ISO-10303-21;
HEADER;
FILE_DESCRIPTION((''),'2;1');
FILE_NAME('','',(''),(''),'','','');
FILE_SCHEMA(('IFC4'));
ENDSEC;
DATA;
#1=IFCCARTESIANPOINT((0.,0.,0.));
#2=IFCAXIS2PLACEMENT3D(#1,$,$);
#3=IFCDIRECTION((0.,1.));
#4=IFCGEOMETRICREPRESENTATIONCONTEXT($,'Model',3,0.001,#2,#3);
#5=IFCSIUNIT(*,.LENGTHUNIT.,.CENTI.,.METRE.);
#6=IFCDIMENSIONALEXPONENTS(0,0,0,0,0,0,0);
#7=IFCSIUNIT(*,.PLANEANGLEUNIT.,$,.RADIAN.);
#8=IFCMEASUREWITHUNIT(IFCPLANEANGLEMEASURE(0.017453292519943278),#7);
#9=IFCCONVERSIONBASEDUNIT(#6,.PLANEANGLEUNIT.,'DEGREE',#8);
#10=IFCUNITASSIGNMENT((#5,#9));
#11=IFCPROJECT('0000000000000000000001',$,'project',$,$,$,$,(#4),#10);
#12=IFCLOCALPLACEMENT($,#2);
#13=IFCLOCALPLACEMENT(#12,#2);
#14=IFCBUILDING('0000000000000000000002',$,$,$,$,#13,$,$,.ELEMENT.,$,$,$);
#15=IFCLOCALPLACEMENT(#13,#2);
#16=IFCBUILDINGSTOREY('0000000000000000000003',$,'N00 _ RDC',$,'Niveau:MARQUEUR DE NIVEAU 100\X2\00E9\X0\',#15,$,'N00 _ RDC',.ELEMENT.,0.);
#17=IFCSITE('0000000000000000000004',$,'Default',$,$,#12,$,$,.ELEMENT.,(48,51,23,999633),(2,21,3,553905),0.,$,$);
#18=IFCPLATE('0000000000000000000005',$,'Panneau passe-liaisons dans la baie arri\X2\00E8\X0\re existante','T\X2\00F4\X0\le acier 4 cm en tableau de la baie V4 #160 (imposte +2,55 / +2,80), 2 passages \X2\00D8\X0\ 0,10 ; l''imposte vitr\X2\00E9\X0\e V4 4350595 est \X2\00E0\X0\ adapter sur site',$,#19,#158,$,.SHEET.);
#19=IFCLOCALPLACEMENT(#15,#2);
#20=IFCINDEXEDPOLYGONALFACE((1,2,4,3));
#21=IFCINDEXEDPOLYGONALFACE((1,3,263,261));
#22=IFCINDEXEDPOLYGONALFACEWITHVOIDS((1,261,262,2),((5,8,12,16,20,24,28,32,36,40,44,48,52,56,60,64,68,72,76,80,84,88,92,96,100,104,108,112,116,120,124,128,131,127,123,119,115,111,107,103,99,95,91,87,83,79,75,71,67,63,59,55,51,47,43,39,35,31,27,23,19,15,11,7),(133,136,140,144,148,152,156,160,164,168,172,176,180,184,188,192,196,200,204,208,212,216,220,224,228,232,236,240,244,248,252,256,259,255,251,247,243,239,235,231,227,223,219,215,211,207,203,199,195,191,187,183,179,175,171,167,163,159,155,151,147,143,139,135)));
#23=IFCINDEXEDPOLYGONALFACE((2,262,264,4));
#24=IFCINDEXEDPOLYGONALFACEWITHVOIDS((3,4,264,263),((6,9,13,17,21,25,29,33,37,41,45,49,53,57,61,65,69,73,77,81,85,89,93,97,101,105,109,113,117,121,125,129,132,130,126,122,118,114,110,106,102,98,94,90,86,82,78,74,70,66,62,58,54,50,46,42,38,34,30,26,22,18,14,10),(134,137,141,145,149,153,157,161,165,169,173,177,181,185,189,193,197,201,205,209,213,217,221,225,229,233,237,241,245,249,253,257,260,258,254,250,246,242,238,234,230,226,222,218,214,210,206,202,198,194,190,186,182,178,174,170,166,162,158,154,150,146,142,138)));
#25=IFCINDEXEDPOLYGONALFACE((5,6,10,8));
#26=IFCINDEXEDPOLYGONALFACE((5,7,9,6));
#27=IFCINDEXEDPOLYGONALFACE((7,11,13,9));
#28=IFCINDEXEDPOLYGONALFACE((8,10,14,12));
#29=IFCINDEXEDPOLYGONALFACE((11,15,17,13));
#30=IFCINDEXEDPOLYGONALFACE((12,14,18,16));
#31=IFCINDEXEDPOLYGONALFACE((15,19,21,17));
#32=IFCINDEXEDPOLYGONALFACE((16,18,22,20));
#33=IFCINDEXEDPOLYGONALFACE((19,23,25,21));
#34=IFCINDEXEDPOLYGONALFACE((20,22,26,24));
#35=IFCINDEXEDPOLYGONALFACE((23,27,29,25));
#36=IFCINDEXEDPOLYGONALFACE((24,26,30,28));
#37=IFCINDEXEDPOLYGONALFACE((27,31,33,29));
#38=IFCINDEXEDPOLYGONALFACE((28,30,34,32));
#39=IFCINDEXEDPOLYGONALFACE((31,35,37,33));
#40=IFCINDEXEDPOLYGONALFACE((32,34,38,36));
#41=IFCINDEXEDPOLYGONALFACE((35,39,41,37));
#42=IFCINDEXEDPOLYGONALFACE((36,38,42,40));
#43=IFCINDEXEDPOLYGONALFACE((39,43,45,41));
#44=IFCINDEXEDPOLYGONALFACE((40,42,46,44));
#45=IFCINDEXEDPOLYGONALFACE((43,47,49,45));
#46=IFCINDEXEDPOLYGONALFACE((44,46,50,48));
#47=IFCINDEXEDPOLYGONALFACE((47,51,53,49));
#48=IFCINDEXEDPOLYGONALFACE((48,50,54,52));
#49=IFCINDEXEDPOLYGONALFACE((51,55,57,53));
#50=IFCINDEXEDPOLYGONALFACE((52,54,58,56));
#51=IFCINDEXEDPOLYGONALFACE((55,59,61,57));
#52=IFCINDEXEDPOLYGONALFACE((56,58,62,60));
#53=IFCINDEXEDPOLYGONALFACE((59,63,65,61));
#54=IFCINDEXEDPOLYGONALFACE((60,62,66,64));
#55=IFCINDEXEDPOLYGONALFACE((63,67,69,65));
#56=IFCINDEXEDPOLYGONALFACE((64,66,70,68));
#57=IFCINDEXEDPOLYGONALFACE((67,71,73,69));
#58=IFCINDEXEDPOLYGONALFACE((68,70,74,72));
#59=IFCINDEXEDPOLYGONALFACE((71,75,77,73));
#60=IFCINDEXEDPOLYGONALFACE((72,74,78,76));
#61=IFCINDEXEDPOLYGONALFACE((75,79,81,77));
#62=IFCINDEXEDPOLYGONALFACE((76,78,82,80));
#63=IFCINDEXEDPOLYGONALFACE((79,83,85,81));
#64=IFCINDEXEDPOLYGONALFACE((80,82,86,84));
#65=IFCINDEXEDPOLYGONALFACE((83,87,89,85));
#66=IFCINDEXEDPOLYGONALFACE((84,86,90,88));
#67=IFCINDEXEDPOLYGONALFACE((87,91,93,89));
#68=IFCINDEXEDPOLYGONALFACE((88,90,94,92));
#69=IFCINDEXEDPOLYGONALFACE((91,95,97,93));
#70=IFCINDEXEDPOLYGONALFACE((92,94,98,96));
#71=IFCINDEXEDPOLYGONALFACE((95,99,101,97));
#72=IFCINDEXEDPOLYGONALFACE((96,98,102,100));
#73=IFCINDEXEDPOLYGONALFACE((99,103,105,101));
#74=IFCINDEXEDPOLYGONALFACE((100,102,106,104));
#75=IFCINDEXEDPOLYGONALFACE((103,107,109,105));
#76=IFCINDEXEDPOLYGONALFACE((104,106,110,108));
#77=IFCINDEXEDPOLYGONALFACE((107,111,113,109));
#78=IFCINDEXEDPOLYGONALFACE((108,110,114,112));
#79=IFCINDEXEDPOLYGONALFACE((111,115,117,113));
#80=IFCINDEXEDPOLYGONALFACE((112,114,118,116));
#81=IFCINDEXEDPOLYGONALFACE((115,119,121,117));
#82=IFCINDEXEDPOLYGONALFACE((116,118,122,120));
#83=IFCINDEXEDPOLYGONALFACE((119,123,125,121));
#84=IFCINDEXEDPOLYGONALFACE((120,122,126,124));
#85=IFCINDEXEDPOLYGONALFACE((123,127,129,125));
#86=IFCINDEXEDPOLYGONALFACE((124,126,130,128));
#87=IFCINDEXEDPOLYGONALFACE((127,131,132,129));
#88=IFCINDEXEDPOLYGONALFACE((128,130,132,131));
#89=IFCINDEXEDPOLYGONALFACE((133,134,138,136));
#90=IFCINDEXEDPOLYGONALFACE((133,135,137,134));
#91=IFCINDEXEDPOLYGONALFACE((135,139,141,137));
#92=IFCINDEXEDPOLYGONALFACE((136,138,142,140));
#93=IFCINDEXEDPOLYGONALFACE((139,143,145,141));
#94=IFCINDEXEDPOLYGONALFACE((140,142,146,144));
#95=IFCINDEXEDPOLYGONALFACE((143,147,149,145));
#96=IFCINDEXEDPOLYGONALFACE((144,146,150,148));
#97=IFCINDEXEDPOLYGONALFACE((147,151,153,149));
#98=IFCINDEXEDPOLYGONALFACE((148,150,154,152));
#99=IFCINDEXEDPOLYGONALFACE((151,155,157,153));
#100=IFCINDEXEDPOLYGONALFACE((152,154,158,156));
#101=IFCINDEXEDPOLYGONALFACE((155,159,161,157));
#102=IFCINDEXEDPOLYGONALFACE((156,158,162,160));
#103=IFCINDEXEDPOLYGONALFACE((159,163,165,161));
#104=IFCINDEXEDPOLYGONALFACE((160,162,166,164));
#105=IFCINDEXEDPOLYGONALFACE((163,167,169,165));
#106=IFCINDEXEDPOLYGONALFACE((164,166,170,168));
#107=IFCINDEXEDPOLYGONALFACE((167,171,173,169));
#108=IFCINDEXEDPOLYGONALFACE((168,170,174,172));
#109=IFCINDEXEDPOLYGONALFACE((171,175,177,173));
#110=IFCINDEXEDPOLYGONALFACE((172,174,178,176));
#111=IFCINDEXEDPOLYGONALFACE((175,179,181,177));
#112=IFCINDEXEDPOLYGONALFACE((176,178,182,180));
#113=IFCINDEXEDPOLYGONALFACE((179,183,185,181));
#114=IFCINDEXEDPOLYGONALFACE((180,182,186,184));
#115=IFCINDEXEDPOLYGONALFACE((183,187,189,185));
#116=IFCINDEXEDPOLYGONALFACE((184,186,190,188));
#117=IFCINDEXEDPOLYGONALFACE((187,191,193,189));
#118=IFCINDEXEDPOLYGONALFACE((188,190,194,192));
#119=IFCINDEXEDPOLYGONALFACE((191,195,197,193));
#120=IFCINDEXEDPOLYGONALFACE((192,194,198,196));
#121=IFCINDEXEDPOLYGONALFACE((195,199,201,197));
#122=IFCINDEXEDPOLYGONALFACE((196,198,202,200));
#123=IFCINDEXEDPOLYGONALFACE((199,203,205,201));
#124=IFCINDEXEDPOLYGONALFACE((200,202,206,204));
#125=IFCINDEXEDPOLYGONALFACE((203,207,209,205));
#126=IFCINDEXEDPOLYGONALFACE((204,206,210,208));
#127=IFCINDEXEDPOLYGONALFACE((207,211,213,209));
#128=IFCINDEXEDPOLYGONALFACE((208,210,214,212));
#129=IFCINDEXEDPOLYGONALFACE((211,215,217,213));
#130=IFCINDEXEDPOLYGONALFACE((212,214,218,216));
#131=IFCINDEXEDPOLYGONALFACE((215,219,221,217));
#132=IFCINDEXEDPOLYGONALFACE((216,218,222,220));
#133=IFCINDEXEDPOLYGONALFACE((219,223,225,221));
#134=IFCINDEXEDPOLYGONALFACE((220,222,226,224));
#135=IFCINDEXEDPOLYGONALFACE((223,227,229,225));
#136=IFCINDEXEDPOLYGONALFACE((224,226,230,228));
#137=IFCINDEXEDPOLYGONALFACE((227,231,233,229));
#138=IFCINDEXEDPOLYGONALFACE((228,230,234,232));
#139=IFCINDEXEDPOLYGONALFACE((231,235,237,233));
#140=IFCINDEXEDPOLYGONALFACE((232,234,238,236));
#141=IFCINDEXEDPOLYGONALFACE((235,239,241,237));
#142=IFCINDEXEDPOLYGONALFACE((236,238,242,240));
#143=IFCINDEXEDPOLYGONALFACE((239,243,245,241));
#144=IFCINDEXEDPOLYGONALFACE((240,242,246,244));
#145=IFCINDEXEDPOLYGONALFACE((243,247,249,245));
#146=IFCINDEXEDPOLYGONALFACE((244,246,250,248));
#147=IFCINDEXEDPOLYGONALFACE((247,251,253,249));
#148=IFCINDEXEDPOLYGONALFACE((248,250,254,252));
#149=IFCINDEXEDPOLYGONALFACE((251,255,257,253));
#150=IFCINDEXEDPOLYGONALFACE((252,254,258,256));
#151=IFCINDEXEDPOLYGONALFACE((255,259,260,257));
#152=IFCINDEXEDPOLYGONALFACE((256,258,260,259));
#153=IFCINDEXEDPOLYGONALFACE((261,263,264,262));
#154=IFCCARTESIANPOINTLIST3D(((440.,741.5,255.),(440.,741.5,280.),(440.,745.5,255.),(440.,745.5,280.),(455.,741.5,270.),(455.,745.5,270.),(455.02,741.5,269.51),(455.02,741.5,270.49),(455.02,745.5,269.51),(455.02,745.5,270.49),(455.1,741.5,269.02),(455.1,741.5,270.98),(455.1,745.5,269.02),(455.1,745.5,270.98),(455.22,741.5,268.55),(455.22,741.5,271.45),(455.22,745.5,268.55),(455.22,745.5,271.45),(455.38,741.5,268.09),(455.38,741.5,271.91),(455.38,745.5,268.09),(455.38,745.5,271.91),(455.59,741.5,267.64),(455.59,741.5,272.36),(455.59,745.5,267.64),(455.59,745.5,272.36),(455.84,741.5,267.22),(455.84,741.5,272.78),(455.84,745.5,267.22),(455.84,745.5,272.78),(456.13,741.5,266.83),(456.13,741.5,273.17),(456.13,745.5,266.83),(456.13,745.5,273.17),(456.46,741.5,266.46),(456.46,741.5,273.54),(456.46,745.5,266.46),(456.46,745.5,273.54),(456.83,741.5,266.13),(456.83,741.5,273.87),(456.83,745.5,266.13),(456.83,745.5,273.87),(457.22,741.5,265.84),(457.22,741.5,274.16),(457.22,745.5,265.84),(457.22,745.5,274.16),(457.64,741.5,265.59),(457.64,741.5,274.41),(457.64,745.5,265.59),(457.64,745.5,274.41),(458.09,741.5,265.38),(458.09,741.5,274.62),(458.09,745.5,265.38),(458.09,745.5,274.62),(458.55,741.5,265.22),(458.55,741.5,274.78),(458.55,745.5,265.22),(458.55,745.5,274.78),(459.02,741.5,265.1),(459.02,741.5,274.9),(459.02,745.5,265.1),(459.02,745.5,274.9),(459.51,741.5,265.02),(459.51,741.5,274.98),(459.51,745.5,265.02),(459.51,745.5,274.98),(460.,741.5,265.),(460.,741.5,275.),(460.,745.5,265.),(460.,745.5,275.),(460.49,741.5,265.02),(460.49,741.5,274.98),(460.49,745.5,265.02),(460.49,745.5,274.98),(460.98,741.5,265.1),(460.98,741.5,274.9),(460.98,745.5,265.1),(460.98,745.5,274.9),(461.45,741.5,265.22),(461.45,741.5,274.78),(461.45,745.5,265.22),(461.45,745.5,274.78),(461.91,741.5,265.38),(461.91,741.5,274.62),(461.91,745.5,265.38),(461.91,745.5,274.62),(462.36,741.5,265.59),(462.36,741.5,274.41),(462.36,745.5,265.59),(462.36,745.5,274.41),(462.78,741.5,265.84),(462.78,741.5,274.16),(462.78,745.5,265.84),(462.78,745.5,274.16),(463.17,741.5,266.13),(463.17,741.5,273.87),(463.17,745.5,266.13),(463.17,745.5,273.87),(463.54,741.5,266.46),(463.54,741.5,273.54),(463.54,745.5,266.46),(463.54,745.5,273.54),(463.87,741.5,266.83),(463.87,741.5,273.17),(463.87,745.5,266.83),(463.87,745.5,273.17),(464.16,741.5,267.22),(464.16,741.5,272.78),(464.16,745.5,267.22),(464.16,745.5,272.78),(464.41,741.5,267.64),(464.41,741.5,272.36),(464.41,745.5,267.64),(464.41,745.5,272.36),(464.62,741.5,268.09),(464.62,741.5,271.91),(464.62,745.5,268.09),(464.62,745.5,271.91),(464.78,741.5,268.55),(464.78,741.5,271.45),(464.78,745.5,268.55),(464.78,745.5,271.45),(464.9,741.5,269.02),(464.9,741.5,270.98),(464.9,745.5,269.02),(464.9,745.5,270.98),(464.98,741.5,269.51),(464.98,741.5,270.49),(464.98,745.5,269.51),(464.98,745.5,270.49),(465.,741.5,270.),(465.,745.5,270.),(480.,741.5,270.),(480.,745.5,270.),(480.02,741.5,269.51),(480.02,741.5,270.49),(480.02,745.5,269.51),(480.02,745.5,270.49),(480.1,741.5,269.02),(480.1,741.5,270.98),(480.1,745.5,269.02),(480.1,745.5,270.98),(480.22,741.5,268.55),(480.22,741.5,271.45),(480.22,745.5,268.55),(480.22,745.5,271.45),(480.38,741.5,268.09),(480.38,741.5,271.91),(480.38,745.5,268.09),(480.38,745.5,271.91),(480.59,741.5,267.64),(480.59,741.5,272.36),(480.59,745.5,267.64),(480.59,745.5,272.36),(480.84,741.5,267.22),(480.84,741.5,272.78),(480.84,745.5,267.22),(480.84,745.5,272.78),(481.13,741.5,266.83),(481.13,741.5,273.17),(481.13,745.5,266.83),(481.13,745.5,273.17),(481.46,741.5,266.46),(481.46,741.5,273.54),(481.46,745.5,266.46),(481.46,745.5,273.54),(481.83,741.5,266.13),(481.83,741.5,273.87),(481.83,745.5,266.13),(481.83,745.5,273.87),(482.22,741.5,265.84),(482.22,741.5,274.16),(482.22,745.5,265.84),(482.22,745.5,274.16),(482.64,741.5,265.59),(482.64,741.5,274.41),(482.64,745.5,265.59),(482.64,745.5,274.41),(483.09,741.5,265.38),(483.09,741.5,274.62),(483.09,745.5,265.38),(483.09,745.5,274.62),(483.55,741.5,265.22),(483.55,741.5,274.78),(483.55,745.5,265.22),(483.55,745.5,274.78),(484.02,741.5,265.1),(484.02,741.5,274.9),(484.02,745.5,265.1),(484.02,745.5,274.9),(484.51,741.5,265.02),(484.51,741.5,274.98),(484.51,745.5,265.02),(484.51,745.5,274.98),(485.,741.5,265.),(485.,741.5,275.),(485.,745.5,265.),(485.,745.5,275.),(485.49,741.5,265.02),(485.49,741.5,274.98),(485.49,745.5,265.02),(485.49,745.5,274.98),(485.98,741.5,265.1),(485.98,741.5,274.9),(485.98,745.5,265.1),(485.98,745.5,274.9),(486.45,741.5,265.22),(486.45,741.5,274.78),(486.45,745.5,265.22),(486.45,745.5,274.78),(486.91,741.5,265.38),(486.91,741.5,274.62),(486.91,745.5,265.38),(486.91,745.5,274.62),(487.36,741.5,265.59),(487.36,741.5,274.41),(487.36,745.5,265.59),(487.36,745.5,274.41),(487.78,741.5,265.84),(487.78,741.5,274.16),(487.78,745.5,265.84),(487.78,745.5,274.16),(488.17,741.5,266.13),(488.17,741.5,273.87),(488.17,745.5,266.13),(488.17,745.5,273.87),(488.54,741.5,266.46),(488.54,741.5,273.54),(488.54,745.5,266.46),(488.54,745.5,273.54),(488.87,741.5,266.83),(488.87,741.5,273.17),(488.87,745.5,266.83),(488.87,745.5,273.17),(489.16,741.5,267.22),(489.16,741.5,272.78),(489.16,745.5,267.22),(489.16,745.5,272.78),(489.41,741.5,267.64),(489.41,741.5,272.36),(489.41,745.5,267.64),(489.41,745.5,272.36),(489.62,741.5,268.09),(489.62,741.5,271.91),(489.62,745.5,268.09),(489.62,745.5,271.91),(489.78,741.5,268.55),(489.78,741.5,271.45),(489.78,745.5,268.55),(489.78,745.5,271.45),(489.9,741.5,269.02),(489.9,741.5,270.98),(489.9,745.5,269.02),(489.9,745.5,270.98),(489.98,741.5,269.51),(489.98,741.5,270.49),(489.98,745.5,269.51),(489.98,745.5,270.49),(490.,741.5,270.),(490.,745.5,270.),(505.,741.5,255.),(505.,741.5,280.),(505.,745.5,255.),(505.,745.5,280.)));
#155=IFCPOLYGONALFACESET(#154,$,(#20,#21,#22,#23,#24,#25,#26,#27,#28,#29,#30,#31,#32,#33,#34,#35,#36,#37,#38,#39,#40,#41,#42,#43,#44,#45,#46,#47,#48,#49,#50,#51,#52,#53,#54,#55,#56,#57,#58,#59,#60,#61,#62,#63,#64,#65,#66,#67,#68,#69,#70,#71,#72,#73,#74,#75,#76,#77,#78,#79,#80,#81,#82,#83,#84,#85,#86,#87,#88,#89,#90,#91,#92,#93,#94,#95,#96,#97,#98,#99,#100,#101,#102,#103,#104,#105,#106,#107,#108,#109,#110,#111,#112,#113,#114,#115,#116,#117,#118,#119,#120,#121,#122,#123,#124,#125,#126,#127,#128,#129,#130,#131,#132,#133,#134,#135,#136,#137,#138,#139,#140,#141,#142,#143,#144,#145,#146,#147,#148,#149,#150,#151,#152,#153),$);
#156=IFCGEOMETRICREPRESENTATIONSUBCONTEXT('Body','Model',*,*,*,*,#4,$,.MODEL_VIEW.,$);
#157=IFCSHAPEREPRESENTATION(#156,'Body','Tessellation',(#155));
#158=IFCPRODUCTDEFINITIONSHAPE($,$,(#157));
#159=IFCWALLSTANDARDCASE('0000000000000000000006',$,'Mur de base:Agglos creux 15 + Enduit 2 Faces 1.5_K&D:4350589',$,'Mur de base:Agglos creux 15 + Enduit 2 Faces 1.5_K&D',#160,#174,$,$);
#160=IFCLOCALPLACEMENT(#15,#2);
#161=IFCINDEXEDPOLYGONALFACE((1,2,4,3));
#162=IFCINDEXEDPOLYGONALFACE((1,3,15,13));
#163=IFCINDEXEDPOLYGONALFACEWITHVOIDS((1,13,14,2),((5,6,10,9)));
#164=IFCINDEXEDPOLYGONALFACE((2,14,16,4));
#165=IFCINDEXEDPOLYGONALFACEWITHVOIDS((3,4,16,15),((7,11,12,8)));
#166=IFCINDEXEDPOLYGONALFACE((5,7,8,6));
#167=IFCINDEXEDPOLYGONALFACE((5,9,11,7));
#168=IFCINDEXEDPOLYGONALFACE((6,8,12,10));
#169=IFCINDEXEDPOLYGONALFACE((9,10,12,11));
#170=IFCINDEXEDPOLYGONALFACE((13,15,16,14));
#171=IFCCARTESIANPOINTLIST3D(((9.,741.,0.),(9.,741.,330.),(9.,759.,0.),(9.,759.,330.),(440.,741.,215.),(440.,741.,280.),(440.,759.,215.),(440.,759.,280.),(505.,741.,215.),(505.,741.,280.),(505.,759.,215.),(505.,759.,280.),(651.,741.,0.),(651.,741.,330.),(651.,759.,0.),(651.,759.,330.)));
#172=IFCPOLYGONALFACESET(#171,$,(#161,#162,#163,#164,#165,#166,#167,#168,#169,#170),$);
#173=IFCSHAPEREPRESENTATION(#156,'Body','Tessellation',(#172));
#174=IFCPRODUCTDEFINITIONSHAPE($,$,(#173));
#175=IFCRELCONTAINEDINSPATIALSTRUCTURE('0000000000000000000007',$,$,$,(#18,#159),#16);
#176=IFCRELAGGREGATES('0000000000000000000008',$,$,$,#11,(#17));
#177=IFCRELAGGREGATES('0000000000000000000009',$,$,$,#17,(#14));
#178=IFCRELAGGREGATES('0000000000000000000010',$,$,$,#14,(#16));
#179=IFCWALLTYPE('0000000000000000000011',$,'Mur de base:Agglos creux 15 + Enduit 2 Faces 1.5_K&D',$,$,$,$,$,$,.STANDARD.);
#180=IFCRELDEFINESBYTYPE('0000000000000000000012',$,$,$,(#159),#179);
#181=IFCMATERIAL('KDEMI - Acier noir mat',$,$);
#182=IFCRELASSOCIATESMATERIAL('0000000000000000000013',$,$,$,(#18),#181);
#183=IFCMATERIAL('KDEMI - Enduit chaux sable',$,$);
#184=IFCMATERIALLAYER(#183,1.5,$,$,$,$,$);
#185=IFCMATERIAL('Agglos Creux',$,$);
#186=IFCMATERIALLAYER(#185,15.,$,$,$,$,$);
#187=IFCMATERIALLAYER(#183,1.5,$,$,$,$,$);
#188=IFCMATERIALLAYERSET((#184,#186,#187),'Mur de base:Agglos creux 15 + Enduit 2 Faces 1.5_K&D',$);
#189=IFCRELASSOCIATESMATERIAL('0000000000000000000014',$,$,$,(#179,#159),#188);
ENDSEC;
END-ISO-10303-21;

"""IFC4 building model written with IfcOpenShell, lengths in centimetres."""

from ifc_helpers import new_model, entity, si_unit, converted_unit, direction, frame, frame_2d, origin, origin_with_axes, place, context, subcontext, project, spatial, polyline, rectangle, outline, extrude, material, layer, layer_set, layer_usage, type_object, element, save


model = new_model("IFC4")

# Units and contexts
model_context = context("Model", 3, precision=0.001, world=origin(), true_north=direction((0.0, 1.0)))
body_context = subcontext(model_context, "Body", "Model", "MODEL_VIEW")
ifc_project = project(units=[si_unit("LENGTHUNIT", "METRE", prefix="CENTI"), converted_unit("PLANEANGLEUNIT", "DEGREE", entity("IfcPlaneAngleMeasure", 0.017453292519943278), si_unit("PLANEANGLEUNIT", "RADIAN"), dimensions=[0, 0, 0, 0, 0, 0, 0])], contexts=[model_context])

# Site, building, storey
site_placement = place(None, origin())
site = spatial("IfcSite", under=ifc_project, at=site_placement, Name="Default", CompositionType="ELEMENT", RefLatitude=(48, 51, 23, 999633), RefLongitude=(2, 21, 3, 553905), RefElevation=0.0)
building_placement = place(site_placement, origin())
building = spatial("IfcBuilding", under=site, at=building_placement, CompositionType="ELEMENT")
storey_placement = place(building_placement, origin())
storey = spatial("IfcBuildingStorey", under=building, at=storey_placement, Name="N00 _ RDC", ObjectType="Niveau:MARQUEUR DE NIVEAU 100é", LongName="N00 _ RDC", CompositionType="ELEMENT", Elevation=0.0)

# Plate
ifc_material_1 = material(Name="KDEMI - Acier noir mat")
plate_placement = place(storey_placement, origin_with_axes())
element("IfcPlate", 1, at=plate_placement, inside=storey, material=ifc_material_1, Name="Panneau passe-liaisons dans la baie arrière existante", Description="Tôle acier 4 cm en tableau de la baie V4 #160 (imposte +2,55 / +2,80), 2 passages Ø 0,10 ; l'imposte vitrée V4 4350595 est à adapter sur site", PredefinedType="SHEET", context=body_context, shape_type="SweptSolid", body=[
    extrude(outline(polyline([(440.0, 255.0), (440.0, 280.0), (505.0, 280.0), (505.0, 255.0), (440.0, 255.0)]), holes=[polyline([(490.0, 270.0), (489.98, 270.49), (489.9, 270.98), (489.78, 271.45), (489.62, 271.91), (489.41, 272.36), (489.16, 272.78), (488.87, 273.17), (488.54, 273.54), (488.17, 273.87), (487.78, 274.16), (487.36, 274.41), (486.91, 274.62), (486.45, 274.78), (485.98, 274.9), (485.49, 274.98), (485.0, 275.0), (484.51, 274.98), (484.02, 274.9), (483.55, 274.78), (483.09, 274.62), (482.64, 274.41), (482.22, 274.16), (481.83, 273.87), (481.46, 273.54), (481.13, 273.17), (480.84, 272.78), (480.59, 272.36), (480.38, 271.91), (480.22, 271.45), (480.1, 270.98), (480.02, 270.49), (480.0, 270.0), (480.02, 269.51), (480.1, 269.02), (480.22, 268.55), (480.38, 268.09), (480.59, 267.64), (480.84, 267.22), (481.13, 266.83), (481.46, 266.46), (481.83, 266.13), (482.22, 265.84), (482.64, 265.59), (483.09, 265.38), (483.55, 265.22), (484.02, 265.1), (484.51, 265.02), (485.0, 265.0), (485.49, 265.02), (485.98, 265.1), (486.45, 265.22), (486.91, 265.38), (487.36, 265.59), (487.78, 265.84), (488.17, 266.13), (488.54, 266.46), (488.87, 266.83), (489.16, 267.22), (489.41, 267.64), (489.62, 268.09), (489.78, 268.55), (489.9, 269.02), (489.98, 269.51), (490.0, 270.0)]), polyline([(465.0, 270.0), (464.98, 270.49), (464.9, 270.98), (464.78, 271.45), (464.62, 271.91), (464.41, 272.36), (464.16, 272.78), (463.87, 273.17), (463.54, 273.54), (463.17, 273.87), (462.78, 274.16), (462.36, 274.41), (461.91, 274.62), (461.45, 274.78), (460.98, 274.9), (460.49, 274.98), (460.0, 275.0), (459.51, 274.98), (459.02, 274.9), (458.55, 274.78), (458.09, 274.62), (457.64, 274.41), (457.22, 274.16), (456.83, 273.87), (456.46, 273.54), (456.13, 273.17), (455.84, 272.78), (455.59, 272.36), (455.38, 271.91), (455.22, 271.45), (455.1, 270.98), (455.02, 270.49), (455.0, 270.0), (455.02, 269.51), (455.1, 269.02), (455.22, 268.55), (455.38, 268.09), (455.59, 267.64), (455.84, 267.22), (456.13, 266.83), (456.46, 266.46), (456.83, 266.13), (457.22, 265.84), (457.64, 265.59), (458.09, 265.38), (458.55, 265.22), (459.02, 265.1), (459.51, 265.02), (460.0, 265.0), (460.49, 265.02), (460.98, 265.1), (461.45, 265.22), (461.91, 265.38), (462.36, 265.59), (462.78, 265.84), (463.17, 266.13), (463.54, 266.46), (463.87, 266.83), (464.16, 267.22), (464.41, 267.64), (464.62, 268.09), (464.78, 268.55), (464.9, 269.02), (464.98, 269.51), (465.0, 270.0)])]), frame((0.0, 745.5, 0.0), z_axis=(0.0, -1.0, 0.0), x_axis=(1.0, 0.0, 0.0)), (0.0, 0.0, 1.0), 4.0),
])

# Wall, opening
ifc_material_2 = material(Name="KDEMI - Enduit chaux sable")
ifc_layer_1 = layer(ifc_material_2, 1.5)
ifc_material_3 = material(Name="Agglos Creux")
ifc_layer_2 = layer(ifc_material_3, 15.0)
ifc_layer_3 = layer(ifc_material_2, 1.5)
ifc_layer_set_1 = layer_set([ifc_layer_1, ifc_layer_2, ifc_layer_3], Name="Mur de base:Agglos creux 15 + Enduit 2 Faces 1.5_K&D")
ifc_layer_usage_1 = layer_usage(ifc_layer_set_1, "AXIS2", "NEGATIVE", 9.0)
wall_type_1 = type_object("IfcWallType", Name="Mur de base:Agglos creux 15 + Enduit 2 Faces 1.5_K&D", PredefinedType="STANDARD", material=ifc_layer_set_1)
wall_1_placement = place(storey_placement, frame((9.0, 750.0, 0.0)))
wall_1 = element("IfcWallStandardCase", 2, at=wall_1_placement, inside=storey, type_object=wall_type_1, material=ifc_layer_usage_1, Name="Mur de base:Agglos creux 15 + Enduit 2 Faces 1.5_K&D:4350589", ObjectType="Mur de base:Agglos creux 15 + Enduit 2 Faces 1.5_K&D", context=body_context, shape_type="SweptSolid", body=[
    extrude(rectangle(XDim=642.0, YDim=18.0, at=frame_2d((321.0, 0.0), x_axis=(-1.0, 0.0))), origin(), (0.0, 0.0, 1.0), 330.0),
])
opening_1_placement = place(wall_1_placement, origin())
element("IfcOpeningElement", 3, at=opening_1_placement, cuts=wall_1, ObjectType="Opening", context=body_context, shape_type="SweptSolid", body=[
    extrude(rectangle(XDim=65.0, YDim=65.0, at=frame_2d((0.0, 0.0), x_axis=(1.0, 0.0))), frame((463.5, -9.0, 247.5), z_axis=(0.0, 1.0, 0.0), x_axis=(0.0, 0.0, -1.0)), (0.0, 0.0, 1.0), 18.0),
])

save(model, "model.ifc")
